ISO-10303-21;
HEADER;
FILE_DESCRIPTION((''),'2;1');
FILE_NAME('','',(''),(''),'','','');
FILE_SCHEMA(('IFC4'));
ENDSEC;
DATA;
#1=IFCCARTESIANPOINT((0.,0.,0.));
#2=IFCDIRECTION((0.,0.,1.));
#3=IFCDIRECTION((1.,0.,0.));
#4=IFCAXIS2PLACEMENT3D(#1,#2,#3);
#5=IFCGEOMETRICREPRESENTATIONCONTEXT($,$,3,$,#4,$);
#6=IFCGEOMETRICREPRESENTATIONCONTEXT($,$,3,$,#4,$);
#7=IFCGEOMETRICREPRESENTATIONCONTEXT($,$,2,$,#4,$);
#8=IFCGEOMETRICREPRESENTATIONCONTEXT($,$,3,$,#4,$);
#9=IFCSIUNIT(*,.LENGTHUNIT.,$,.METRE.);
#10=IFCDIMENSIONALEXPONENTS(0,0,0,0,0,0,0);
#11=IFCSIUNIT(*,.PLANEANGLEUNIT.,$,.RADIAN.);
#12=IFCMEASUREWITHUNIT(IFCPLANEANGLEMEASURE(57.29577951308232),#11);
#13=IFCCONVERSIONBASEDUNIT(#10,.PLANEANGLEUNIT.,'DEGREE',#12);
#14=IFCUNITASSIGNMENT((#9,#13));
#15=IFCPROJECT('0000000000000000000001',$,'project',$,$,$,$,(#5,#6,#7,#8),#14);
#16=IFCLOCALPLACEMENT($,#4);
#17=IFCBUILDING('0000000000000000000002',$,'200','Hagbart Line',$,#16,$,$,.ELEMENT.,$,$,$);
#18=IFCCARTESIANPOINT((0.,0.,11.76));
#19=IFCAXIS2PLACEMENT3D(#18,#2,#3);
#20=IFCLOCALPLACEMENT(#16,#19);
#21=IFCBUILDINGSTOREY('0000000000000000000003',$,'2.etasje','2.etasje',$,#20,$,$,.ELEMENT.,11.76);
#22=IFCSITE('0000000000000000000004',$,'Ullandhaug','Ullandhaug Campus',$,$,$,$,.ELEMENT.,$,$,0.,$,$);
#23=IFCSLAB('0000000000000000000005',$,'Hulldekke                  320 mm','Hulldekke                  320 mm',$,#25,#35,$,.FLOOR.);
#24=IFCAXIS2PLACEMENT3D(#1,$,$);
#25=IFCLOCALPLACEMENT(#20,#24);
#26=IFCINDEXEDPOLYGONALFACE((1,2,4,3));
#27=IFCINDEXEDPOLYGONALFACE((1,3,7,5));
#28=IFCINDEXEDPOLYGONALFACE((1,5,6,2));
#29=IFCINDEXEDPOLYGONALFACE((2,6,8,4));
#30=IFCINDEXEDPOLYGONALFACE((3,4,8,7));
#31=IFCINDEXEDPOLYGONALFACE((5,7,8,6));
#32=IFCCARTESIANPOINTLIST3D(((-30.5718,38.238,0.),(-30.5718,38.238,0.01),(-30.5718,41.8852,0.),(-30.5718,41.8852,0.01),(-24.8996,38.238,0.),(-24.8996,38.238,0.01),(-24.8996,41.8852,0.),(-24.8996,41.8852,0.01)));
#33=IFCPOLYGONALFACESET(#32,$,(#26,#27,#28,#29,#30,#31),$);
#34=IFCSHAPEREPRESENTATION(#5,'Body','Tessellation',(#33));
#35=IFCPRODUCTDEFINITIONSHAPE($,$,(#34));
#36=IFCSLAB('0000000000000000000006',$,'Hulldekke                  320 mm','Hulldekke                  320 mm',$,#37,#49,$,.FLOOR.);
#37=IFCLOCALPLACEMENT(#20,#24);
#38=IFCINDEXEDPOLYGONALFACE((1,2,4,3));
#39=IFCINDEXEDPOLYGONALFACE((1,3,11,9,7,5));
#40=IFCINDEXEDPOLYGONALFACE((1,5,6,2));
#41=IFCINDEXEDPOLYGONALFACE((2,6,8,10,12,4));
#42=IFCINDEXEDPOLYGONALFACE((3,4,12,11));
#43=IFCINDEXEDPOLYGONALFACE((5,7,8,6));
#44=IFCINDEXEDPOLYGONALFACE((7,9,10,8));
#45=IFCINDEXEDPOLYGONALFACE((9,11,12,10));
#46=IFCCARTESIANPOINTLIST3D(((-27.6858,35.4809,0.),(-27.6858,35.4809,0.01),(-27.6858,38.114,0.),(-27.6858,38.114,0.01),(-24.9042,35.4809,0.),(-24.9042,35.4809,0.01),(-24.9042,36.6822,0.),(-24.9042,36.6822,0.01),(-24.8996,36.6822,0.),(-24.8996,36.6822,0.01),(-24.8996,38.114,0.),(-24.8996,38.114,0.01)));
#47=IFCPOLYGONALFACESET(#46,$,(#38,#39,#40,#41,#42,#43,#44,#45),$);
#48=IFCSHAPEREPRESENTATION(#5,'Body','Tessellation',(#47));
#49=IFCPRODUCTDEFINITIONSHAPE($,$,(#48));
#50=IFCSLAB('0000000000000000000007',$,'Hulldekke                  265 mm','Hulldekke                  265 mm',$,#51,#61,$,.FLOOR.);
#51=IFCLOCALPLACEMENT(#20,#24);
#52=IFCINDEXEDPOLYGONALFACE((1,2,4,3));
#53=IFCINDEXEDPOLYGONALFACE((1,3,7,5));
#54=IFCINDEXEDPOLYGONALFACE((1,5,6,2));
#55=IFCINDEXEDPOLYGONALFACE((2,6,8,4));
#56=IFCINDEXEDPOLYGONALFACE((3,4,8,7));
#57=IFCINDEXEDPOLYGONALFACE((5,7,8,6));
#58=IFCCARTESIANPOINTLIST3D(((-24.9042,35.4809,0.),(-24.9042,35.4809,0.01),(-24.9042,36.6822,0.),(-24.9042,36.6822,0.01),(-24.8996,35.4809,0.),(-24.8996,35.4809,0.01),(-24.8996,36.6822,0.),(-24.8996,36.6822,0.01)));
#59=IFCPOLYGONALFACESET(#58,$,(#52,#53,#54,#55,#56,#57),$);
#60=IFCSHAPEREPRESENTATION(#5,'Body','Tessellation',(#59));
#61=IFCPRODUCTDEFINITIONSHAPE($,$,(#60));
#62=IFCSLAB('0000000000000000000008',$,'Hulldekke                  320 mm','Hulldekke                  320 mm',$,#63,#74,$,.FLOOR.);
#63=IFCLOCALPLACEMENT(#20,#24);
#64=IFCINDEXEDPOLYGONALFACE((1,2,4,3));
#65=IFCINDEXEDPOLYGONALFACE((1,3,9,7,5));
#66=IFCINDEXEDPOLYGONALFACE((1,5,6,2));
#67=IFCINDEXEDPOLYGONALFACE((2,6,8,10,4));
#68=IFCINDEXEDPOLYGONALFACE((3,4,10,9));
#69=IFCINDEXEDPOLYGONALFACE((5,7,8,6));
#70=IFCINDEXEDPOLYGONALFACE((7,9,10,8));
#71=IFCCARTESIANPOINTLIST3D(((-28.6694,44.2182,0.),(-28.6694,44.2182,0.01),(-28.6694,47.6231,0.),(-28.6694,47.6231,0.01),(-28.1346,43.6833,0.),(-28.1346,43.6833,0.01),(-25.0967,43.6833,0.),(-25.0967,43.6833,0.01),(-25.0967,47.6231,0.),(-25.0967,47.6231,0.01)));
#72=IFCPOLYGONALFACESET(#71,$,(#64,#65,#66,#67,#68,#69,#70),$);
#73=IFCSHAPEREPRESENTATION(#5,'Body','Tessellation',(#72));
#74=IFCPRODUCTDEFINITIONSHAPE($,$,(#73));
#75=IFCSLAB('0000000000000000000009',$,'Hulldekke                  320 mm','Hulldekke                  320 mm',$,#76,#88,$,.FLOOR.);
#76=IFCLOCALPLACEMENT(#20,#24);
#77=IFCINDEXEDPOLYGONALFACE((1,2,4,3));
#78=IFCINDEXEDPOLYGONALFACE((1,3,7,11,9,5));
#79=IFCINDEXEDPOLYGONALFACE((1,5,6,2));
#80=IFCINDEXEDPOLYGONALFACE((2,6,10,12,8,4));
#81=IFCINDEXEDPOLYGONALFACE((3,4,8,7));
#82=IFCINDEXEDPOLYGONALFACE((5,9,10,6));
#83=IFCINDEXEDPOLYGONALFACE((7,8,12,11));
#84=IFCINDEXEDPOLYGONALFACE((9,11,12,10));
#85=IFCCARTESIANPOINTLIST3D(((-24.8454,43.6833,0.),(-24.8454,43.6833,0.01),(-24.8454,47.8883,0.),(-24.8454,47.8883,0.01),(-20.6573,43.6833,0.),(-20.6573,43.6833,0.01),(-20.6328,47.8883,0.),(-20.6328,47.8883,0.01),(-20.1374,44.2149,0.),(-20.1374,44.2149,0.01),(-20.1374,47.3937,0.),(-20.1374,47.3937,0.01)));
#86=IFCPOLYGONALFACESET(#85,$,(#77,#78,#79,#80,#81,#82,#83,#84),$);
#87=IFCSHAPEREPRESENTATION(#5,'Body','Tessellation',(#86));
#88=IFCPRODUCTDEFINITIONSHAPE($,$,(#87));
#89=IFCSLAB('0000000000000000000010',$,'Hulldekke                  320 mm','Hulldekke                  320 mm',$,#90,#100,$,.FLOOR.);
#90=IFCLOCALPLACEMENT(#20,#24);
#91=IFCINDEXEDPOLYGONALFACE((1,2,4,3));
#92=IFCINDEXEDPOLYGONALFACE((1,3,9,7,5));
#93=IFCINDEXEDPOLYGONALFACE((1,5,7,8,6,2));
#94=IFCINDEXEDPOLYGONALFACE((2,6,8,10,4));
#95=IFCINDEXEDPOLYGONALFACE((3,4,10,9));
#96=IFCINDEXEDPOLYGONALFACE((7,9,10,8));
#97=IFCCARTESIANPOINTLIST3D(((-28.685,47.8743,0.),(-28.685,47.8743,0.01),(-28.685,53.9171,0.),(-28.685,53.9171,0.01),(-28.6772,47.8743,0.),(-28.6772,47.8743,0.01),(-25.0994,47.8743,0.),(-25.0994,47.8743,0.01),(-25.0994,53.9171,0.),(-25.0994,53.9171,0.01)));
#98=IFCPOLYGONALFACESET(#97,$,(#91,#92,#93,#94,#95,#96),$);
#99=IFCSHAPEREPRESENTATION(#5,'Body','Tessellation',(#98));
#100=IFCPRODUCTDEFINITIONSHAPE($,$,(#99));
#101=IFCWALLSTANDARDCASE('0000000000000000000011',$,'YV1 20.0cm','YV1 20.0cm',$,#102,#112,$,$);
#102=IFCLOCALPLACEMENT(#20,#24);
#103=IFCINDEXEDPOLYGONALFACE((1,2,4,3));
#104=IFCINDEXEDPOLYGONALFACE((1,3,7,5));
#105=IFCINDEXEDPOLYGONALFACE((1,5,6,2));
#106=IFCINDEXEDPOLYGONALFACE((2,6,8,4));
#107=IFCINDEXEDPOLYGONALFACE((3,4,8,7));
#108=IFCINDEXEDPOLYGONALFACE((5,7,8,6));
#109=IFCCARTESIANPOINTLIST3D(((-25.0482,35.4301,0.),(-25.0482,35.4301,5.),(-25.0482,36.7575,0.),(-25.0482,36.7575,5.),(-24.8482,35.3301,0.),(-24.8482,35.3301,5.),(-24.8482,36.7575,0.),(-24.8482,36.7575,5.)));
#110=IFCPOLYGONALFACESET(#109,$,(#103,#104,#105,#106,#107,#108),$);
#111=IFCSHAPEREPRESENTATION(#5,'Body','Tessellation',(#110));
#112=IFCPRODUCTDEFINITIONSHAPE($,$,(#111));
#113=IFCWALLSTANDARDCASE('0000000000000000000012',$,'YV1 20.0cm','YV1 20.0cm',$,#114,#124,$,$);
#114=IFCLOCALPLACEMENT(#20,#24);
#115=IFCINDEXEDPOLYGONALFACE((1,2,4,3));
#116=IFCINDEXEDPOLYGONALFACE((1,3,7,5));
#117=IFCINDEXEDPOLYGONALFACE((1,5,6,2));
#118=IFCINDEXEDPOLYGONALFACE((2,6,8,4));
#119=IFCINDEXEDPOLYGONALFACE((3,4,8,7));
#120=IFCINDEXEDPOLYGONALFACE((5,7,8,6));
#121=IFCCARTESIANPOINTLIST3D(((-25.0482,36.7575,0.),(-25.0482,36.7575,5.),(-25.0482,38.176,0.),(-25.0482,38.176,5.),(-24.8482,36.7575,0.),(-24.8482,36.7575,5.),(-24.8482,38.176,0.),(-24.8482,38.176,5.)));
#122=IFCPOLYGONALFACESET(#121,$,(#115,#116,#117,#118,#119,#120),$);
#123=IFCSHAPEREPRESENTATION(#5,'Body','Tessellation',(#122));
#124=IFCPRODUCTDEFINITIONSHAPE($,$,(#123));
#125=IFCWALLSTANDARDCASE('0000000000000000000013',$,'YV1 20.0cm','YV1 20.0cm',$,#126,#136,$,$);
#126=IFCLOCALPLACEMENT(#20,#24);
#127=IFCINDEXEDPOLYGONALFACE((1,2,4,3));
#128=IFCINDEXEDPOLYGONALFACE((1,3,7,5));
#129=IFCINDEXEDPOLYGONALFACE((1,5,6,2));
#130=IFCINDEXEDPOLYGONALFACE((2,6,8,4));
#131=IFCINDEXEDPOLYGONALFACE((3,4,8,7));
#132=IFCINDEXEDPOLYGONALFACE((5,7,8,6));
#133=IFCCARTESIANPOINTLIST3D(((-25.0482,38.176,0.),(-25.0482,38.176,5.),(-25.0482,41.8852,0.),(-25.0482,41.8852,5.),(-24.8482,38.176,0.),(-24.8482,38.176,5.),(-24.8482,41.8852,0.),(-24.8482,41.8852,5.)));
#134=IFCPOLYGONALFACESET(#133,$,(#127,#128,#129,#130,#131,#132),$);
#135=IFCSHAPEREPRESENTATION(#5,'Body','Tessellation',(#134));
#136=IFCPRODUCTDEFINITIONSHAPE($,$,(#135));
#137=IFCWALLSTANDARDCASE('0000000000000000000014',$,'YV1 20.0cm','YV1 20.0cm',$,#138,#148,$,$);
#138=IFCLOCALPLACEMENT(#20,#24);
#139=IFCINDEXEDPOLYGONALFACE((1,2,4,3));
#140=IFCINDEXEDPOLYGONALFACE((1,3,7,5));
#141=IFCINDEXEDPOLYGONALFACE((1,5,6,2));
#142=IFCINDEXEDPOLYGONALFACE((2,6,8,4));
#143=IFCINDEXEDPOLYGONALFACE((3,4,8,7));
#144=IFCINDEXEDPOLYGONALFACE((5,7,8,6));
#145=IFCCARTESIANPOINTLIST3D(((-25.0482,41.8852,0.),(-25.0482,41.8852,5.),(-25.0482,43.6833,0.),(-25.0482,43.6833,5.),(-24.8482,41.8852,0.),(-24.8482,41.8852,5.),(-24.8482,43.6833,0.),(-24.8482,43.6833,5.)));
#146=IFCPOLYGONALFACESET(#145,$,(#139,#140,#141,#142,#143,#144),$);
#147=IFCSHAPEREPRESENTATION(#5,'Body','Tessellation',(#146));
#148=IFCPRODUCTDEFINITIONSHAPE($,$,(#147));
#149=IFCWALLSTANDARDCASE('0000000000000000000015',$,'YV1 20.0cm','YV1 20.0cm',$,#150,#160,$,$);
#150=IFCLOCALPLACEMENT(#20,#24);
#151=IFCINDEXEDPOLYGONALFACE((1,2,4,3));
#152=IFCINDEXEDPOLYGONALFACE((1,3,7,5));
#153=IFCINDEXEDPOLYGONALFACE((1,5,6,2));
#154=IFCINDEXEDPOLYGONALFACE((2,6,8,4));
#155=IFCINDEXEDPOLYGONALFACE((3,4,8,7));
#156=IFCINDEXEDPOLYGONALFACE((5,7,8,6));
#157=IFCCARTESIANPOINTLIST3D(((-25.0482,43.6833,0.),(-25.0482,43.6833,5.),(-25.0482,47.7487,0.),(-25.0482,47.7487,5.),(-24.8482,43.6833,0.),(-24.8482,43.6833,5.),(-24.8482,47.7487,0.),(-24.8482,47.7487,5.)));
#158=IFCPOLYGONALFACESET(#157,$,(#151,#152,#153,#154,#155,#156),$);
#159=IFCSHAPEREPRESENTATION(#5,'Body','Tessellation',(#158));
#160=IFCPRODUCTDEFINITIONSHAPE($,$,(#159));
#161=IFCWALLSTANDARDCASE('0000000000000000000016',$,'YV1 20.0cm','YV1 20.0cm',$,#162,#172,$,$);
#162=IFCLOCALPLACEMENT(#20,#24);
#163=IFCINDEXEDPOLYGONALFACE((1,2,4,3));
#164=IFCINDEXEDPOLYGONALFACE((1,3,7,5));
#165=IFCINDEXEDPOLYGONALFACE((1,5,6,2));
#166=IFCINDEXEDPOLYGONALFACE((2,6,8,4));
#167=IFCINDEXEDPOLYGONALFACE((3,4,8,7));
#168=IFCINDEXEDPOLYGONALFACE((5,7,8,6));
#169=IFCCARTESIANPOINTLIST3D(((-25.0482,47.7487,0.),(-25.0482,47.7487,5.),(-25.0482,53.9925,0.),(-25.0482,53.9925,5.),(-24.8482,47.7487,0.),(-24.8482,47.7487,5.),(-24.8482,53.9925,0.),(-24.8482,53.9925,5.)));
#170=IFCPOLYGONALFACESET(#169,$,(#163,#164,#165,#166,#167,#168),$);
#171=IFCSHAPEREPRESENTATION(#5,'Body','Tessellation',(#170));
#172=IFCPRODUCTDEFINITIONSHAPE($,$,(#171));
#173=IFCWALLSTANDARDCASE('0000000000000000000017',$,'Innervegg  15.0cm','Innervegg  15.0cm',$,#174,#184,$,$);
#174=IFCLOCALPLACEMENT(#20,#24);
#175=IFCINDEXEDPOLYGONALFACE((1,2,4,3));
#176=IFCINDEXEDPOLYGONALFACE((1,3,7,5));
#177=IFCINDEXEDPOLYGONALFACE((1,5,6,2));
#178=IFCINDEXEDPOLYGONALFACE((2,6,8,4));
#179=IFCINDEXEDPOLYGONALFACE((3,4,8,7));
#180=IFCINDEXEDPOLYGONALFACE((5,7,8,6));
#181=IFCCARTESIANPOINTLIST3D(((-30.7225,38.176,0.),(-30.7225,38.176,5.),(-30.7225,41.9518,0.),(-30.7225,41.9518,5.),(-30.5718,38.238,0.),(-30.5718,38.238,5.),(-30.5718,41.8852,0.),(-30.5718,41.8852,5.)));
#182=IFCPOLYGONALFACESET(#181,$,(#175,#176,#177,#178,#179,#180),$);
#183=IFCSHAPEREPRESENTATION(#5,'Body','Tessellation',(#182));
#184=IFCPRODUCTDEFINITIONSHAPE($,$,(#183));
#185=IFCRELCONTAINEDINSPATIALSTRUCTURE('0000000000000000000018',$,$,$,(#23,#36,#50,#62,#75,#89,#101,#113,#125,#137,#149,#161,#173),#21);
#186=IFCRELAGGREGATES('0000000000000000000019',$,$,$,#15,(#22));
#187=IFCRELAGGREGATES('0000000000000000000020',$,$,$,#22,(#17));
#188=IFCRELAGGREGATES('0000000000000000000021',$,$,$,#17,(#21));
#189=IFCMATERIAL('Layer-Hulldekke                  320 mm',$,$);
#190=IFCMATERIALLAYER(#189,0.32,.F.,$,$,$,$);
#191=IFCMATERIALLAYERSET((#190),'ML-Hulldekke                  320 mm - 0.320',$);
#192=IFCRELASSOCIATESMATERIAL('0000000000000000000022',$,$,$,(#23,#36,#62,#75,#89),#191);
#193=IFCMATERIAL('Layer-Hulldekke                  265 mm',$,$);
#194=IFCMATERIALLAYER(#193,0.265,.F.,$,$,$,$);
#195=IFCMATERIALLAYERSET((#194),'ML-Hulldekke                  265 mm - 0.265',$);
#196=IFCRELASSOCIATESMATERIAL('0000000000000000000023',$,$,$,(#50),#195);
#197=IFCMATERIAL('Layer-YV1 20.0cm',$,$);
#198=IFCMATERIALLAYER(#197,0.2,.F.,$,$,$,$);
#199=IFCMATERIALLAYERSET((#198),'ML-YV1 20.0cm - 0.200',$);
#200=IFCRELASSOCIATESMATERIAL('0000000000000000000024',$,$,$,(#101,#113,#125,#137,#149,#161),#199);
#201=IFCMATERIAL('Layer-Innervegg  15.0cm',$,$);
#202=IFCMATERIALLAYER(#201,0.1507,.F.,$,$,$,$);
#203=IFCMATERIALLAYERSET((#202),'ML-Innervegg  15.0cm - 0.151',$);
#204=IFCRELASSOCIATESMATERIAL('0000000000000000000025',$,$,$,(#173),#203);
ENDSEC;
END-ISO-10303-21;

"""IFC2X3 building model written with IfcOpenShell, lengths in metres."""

from ifc_helpers import new_model, entity, si_unit, converted_unit, frame, origin_with_axes, place, context, project, spatial, polyline, outline, extrude, material, layer, layer_set, layer_usage, element, save


model = new_model("IFC2X3")

# Units and contexts
context_of_model_1 = context(None, 3, world=origin_with_axes())
context_of_model_2 = context(None, 3, world=origin_with_axes())
context_of_model_3 = context(None, 2, world=origin_with_axes())
context_of_model_4 = context(None, 3, world=origin_with_axes())
ifc_project = project(units=[si_unit("LENGTHUNIT", "METRE"), converted_unit("PLANEANGLEUNIT", "DEGREE", entity("IfcPlaneAngleMeasure", 57.29577951308232), si_unit("PLANEANGLEUNIT", "RADIAN"), dimensions=[0, 0, 0, 0, 0, 0, 0])], contexts=[context_of_model_1, context_of_model_2, context_of_model_3, context_of_model_4])

# Site, building, storey
site = spatial("IfcSite", under=ifc_project, Name="Ullandhaug", Description="Ullandhaug Campus", CompositionType="ELEMENT", RefElevation=0.0)
building_placement = place(None, origin_with_axes())
building = spatial("IfcBuilding", under=site, at=building_placement, Name="200", Description="Hagbart Line", CompositionType="ELEMENT")
storey_placement = place(building_placement, frame((0.0, 0.0, 11.76), z_axis=(0.0, 0.0, 1.0), x_axis=(1.0, 0.0, 0.0)))
storey = spatial("IfcBuildingStorey", under=building, at=storey_placement, Name="2.etasje", Description="2.etasje", CompositionType="ELEMENT", Elevation=11.76)

# Slabs
ifc_material_1 = material(Name="Layer-Hulldekke                  320 mm")
ifc_layer_1 = layer(ifc_material_1, 0.32, ventilated=False)
ifc_layer_set_1 = layer_set([ifc_layer_1], Name="ML-Hulldekke                  320 mm - 0.320")
ifc_layer_usage_1 = layer_usage(ifc_layer_set_1, "AXIS2", "POSITIVE", 0.0)
slab_1_placement = place(storey_placement, frame((-30.5718, 38.238, 0.0), z_axis=(0.0, 0.0, 1.0), x_axis=(1.0, 0.0, 0.0)))
element("IfcSlab", 1, at=slab_1_placement, inside=storey, material=ifc_layer_usage_1, Name="Hulldekke                  320 mm", Description="Hulldekke                  320 mm", PredefinedType="FLOOR", context=context_of_model_1, shape_type="SweptSolid", body=[
    extrude(outline(polyline([(0.0, 0.0), (5.6722, 0.0), (5.6722, 3.6472), (0.0, 3.6472), (0.0, 0.0)])), origin_with_axes(), (0.0, 0.0, 1.0), 0.01),
])
slab_2_placement = place(storey_placement, frame((-24.9042, 35.4809, 0.0), z_axis=(0.0, 0.0, 1.0), x_axis=(1.0, 0.0, 0.0)))
element("IfcSlab", 2, at=slab_2_placement, inside=storey, material=ifc_layer_usage_1, Name="Hulldekke                  320 mm", Description="Hulldekke                  320 mm", PredefinedType="FLOOR", context=context_of_model_1, shape_type="SweptSolid", body=[
    extrude(outline(polyline([(0.0, 0.0), (1.2013, 0.0), (1.2013, 0.0046), (2.6331, 0.0046), (2.6331, -2.7816), (0.0, -2.7816), (0.0, 0.0)])), frame((0.0, 0.0, 0.0), z_axis=(0.0, 0.0, -1.0), x_axis=(0.0, 1.0, 0.0)), (0.0, 0.0, -1.0), 0.01),
])
ifc_material_2 = material(Name="Layer-Hulldekke                  265 mm")
ifc_layer_2 = layer(ifc_material_2, 0.265, ventilated=False)
ifc_layer_set_2 = layer_set([ifc_layer_2], Name="ML-Hulldekke                  265 mm - 0.265")
ifc_layer_usage_2 = layer_usage(ifc_layer_set_2, "AXIS2", "POSITIVE", 0.0)
slab_3_placement = place(storey_placement, frame((-24.8996, 36.6822, 0.0), z_axis=(0.0, 0.0, 1.0), x_axis=(1.0, 0.0, 0.0)))
element("IfcSlab", 3, at=slab_3_placement, inside=storey, material=ifc_layer_usage_2, Name="Hulldekke                  265 mm", Description="Hulldekke                  265 mm", PredefinedType="FLOOR", context=context_of_model_1, shape_type="SweptSolid", body=[
    extrude(outline(polyline([(0.0, 0.0), (0.0046, 0.0), (0.0046, 1.2013), (0.0, 1.2013), (0.0, 0.0)])), frame((0.0, 0.0, 0.0), z_axis=(0.0, 0.0, 1.0), x_axis=(-1.0, 0.0, 0.0)), (0.0, 0.0, 1.0), 0.01),
])
slab_4_placement = place(storey_placement, frame((-28.1346, 43.6833, 0.0), z_axis=(0.0, 0.0, 1.0), x_axis=(1.0, 0.0, 0.0)))
element("IfcSlab", 4, at=slab_4_placement, inside=storey, material=ifc_layer_usage_1, Name="Hulldekke                  320 mm", Description="Hulldekke                  320 mm", PredefinedType="FLOOR", context=context_of_model_1, shape_type="SweptSolid", body=[
    extrude(outline(polyline([(0.0, 0.0), (3.0379, 0.0), (3.0379, 3.9397), (-0.5348, 3.9397), (-0.5348, 0.5348), (0.0, 0.0)])), origin_with_axes(), (0.0, 0.0, 1.0), 0.01),
])
slab_5_placement = place(storey_placement, frame((-24.8454, 43.6833, 0.0), z_axis=(0.0, 0.0, 1.0), x_axis=(1.0, 0.0, 0.0)))
element("IfcSlab", 5, at=slab_5_placement, inside=storey, material=ifc_layer_usage_1, Name="Hulldekke                  320 mm", Description="Hulldekke                  320 mm", PredefinedType="FLOOR", context=context_of_model_1, shape_type="SweptSolid", body=[
    extrude(outline(polyline([(0.0, 0.0), (4.1882, 0.0), (4.708, 0.5316), (4.708, 3.7103), (4.2127, 4.2049), (0.0, 4.2049), (0.0, 0.0)])), origin_with_axes(), (0.0, 0.0, 1.0), 0.01),
])
slab_6_placement = place(storey_placement, frame((-28.6772, 47.8743, 0.0), z_axis=(0.0, 0.0, 1.0), x_axis=(1.0, 0.0, 0.0)))
element("IfcSlab", 6, at=slab_6_placement, inside=storey, material=ifc_layer_usage_1, Name="Hulldekke                  320 mm", Description="Hulldekke                  320 mm", PredefinedType="FLOOR", context=context_of_model_1, shape_type="SweptSolid", body=[
    extrude(outline(polyline([(0.0, 0.0), (3.5778, 0.0), (3.5778, 6.0428), (-0.0078, 6.0428), (-0.0078, 0.0), (0.0, 0.0)])), origin_with_axes(), (0.0, 0.0, 1.0), 0.01),
])

# Walls
ifc_material_3 = material(Name="Layer-YV1 20.0cm")
ifc_layer_3 = layer(ifc_material_3, 0.2, ventilated=False)
ifc_layer_set_3 = layer_set([ifc_layer_3], Name="ML-YV1 20.0cm - 0.200")
ifc_layer_usage_3 = layer_usage(ifc_layer_set_3, "AXIS2", "POSITIVE", 0.0)
wall_1_placement = place(storey_placement, frame((-24.8482, 35.3301, 0.0), z_axis=(0.0, 0.0, 1.0), x_axis=(0.0, 1.0, 0.0)))
element("IfcWallStandardCase", 7, at=wall_1_placement, inside=storey, material=ifc_layer_usage_3, Name="YV1 20.0cm", Description="YV1 20.0cm", context=context_of_model_1, shape_type="SweptSolid", body=[
    extrude(outline(polyline([(0.0, 0.0), (1.4274, 0.0), (1.4274, 0.2), (0.1, 0.2), (0.0, 0.0)])), frame((0.0, 0.0, 0.0), z_axis=(0.0, 0.0, 1.0), x_axis=(1.0, 0.0, 0.0)), (0.0, 0.0, 1.0), 5.0),
])
wall_2_placement = place(storey_placement, frame((-24.8482, 36.7575, 0.0), z_axis=(0.0, 0.0, 1.0), x_axis=(0.0, 1.0, 0.0)))
element("IfcWallStandardCase", 8, at=wall_2_placement, inside=storey, material=ifc_layer_usage_3, Name="YV1 20.0cm", Description="YV1 20.0cm", context=context_of_model_1, shape_type="SweptSolid", body=[
    extrude(outline(polyline([(0.0, 0.0), (1.4185, 0.0), (1.4185, 0.2), (0.0, 0.2), (0.0, 0.0)])), frame((0.0, 0.0, 0.0), z_axis=(0.0, 0.0, 1.0), x_axis=(1.0, 0.0, 0.0)), (0.0, 0.0, 1.0), 5.0),
])
wall_3_placement = place(storey_placement, frame((-24.8482, 38.176, 0.0), z_axis=(0.0, 0.0, 1.0), x_axis=(0.0, 1.0, 0.0)))
element("IfcWallStandardCase", 9, at=wall_3_placement, inside=storey, material=ifc_layer_usage_3, Name="YV1 20.0cm", Description="YV1 20.0cm", context=context_of_model_1, shape_type="SweptSolid", body=[
    extrude(outline(polyline([(0.0, 0.0), (3.7092, 0.0), (3.7092, 0.2), (0.0, 0.2), (0.0, 0.0)])), frame((0.0, 0.0, 0.0), z_axis=(0.0, 0.0, 1.0), x_axis=(1.0, 0.0, 0.0)), (0.0, 0.0, 1.0), 5.0),
])
wall_4_placement = place(storey_placement, frame((-24.8482, 41.8852, 0.0), z_axis=(0.0, 0.0, 1.0), x_axis=(0.0, 1.0, 0.0)))
element("IfcWallStandardCase", 10, at=wall_4_placement, inside=storey, material=ifc_layer_usage_3, Name="YV1 20.0cm", Description="YV1 20.0cm", context=context_of_model_1, shape_type="SweptSolid", body=[
    extrude(outline(polyline([(0.0, 0.0), (1.7981, 0.0), (1.7981, 0.2), (0.0, 0.2), (0.0, 0.0)])), frame((0.0, 0.0, 0.0), z_axis=(0.0, 0.0, 1.0), x_axis=(1.0, 0.0, 0.0)), (0.0, 0.0, 1.0), 5.0),
])
wall_5_placement = place(storey_placement, frame((-24.8482, 43.6833, 0.0), z_axis=(0.0, 0.0, 1.0), x_axis=(0.0, 1.0, 0.0)))
element("IfcWallStandardCase", 11, at=wall_5_placement, inside=storey, material=ifc_layer_usage_3, Name="YV1 20.0cm", Description="YV1 20.0cm", context=context_of_model_1, shape_type="SweptSolid", body=[
    extrude(outline(polyline([(0.0, 0.0), (4.0653, 0.0), (4.0653, 0.2), (0.0, 0.2), (0.0, 0.0)])), frame((0.0, 0.0, 0.0), z_axis=(0.0, 0.0, 1.0), x_axis=(1.0, 0.0, 0.0)), (0.0, 0.0, 1.0), 5.0),
])
wall_6_placement = place(storey_placement, frame((-24.8482, 47.7487, 0.0), z_axis=(0.0, 0.0, 1.0), x_axis=(0.0, 1.0, 0.0)))
element("IfcWallStandardCase", 12, at=wall_6_placement, inside=storey, material=ifc_layer_usage_3, Name="YV1 20.0cm", Description="YV1 20.0cm", context=context_of_model_1, shape_type="SweptSolid", body=[
    extrude(outline(polyline([(0.0, 0.0), (6.2438, 0.0), (6.2438, 0.2), (0.0, 0.2), (0.0, 0.0)])), frame((0.0, 0.0, 0.0), z_axis=(0.0, 0.0, 1.0), x_axis=(1.0, 0.0, 0.0)), (0.0, 0.0, 1.0), 5.0),
])
ifc_material_4 = material(Name="Layer-Innervegg  15.0cm")
ifc_layer_4 = layer(ifc_material_4, 0.1507, ventilated=False)
ifc_layer_set_4 = layer_set([ifc_layer_4], Name="ML-Innervegg  15.0cm - 0.151")
ifc_layer_usage_4 = layer_usage(ifc_layer_set_4, "AXIS2", "POSITIVE", 0.0)
wall_7_placement = place(storey_placement, frame((-30.5718, 38.238, 0.0), z_axis=(0.0, 0.0, 1.0), x_axis=(0.0, 1.0, 0.0)))
element("IfcWallStandardCase", 13, at=wall_7_placement, inside=storey, material=ifc_layer_usage_4, Name="Innervegg  15.0cm", Description="Innervegg  15.0cm", context=context_of_model_1, shape_type="SweptSolid", body=[
    extrude(outline(polyline([(0.0, 0.0), (3.6472, 0.0), (3.7138, 0.1507), (-0.062, 0.1507), (0.0, 0.0)])), frame((0.0, 0.0, 0.0), z_axis=(0.0, 0.0, 1.0), x_axis=(1.0, 0.0, 0.0)), (0.0, 0.0, 1.0), 5.0),
])

save(model, "model.ifc")
